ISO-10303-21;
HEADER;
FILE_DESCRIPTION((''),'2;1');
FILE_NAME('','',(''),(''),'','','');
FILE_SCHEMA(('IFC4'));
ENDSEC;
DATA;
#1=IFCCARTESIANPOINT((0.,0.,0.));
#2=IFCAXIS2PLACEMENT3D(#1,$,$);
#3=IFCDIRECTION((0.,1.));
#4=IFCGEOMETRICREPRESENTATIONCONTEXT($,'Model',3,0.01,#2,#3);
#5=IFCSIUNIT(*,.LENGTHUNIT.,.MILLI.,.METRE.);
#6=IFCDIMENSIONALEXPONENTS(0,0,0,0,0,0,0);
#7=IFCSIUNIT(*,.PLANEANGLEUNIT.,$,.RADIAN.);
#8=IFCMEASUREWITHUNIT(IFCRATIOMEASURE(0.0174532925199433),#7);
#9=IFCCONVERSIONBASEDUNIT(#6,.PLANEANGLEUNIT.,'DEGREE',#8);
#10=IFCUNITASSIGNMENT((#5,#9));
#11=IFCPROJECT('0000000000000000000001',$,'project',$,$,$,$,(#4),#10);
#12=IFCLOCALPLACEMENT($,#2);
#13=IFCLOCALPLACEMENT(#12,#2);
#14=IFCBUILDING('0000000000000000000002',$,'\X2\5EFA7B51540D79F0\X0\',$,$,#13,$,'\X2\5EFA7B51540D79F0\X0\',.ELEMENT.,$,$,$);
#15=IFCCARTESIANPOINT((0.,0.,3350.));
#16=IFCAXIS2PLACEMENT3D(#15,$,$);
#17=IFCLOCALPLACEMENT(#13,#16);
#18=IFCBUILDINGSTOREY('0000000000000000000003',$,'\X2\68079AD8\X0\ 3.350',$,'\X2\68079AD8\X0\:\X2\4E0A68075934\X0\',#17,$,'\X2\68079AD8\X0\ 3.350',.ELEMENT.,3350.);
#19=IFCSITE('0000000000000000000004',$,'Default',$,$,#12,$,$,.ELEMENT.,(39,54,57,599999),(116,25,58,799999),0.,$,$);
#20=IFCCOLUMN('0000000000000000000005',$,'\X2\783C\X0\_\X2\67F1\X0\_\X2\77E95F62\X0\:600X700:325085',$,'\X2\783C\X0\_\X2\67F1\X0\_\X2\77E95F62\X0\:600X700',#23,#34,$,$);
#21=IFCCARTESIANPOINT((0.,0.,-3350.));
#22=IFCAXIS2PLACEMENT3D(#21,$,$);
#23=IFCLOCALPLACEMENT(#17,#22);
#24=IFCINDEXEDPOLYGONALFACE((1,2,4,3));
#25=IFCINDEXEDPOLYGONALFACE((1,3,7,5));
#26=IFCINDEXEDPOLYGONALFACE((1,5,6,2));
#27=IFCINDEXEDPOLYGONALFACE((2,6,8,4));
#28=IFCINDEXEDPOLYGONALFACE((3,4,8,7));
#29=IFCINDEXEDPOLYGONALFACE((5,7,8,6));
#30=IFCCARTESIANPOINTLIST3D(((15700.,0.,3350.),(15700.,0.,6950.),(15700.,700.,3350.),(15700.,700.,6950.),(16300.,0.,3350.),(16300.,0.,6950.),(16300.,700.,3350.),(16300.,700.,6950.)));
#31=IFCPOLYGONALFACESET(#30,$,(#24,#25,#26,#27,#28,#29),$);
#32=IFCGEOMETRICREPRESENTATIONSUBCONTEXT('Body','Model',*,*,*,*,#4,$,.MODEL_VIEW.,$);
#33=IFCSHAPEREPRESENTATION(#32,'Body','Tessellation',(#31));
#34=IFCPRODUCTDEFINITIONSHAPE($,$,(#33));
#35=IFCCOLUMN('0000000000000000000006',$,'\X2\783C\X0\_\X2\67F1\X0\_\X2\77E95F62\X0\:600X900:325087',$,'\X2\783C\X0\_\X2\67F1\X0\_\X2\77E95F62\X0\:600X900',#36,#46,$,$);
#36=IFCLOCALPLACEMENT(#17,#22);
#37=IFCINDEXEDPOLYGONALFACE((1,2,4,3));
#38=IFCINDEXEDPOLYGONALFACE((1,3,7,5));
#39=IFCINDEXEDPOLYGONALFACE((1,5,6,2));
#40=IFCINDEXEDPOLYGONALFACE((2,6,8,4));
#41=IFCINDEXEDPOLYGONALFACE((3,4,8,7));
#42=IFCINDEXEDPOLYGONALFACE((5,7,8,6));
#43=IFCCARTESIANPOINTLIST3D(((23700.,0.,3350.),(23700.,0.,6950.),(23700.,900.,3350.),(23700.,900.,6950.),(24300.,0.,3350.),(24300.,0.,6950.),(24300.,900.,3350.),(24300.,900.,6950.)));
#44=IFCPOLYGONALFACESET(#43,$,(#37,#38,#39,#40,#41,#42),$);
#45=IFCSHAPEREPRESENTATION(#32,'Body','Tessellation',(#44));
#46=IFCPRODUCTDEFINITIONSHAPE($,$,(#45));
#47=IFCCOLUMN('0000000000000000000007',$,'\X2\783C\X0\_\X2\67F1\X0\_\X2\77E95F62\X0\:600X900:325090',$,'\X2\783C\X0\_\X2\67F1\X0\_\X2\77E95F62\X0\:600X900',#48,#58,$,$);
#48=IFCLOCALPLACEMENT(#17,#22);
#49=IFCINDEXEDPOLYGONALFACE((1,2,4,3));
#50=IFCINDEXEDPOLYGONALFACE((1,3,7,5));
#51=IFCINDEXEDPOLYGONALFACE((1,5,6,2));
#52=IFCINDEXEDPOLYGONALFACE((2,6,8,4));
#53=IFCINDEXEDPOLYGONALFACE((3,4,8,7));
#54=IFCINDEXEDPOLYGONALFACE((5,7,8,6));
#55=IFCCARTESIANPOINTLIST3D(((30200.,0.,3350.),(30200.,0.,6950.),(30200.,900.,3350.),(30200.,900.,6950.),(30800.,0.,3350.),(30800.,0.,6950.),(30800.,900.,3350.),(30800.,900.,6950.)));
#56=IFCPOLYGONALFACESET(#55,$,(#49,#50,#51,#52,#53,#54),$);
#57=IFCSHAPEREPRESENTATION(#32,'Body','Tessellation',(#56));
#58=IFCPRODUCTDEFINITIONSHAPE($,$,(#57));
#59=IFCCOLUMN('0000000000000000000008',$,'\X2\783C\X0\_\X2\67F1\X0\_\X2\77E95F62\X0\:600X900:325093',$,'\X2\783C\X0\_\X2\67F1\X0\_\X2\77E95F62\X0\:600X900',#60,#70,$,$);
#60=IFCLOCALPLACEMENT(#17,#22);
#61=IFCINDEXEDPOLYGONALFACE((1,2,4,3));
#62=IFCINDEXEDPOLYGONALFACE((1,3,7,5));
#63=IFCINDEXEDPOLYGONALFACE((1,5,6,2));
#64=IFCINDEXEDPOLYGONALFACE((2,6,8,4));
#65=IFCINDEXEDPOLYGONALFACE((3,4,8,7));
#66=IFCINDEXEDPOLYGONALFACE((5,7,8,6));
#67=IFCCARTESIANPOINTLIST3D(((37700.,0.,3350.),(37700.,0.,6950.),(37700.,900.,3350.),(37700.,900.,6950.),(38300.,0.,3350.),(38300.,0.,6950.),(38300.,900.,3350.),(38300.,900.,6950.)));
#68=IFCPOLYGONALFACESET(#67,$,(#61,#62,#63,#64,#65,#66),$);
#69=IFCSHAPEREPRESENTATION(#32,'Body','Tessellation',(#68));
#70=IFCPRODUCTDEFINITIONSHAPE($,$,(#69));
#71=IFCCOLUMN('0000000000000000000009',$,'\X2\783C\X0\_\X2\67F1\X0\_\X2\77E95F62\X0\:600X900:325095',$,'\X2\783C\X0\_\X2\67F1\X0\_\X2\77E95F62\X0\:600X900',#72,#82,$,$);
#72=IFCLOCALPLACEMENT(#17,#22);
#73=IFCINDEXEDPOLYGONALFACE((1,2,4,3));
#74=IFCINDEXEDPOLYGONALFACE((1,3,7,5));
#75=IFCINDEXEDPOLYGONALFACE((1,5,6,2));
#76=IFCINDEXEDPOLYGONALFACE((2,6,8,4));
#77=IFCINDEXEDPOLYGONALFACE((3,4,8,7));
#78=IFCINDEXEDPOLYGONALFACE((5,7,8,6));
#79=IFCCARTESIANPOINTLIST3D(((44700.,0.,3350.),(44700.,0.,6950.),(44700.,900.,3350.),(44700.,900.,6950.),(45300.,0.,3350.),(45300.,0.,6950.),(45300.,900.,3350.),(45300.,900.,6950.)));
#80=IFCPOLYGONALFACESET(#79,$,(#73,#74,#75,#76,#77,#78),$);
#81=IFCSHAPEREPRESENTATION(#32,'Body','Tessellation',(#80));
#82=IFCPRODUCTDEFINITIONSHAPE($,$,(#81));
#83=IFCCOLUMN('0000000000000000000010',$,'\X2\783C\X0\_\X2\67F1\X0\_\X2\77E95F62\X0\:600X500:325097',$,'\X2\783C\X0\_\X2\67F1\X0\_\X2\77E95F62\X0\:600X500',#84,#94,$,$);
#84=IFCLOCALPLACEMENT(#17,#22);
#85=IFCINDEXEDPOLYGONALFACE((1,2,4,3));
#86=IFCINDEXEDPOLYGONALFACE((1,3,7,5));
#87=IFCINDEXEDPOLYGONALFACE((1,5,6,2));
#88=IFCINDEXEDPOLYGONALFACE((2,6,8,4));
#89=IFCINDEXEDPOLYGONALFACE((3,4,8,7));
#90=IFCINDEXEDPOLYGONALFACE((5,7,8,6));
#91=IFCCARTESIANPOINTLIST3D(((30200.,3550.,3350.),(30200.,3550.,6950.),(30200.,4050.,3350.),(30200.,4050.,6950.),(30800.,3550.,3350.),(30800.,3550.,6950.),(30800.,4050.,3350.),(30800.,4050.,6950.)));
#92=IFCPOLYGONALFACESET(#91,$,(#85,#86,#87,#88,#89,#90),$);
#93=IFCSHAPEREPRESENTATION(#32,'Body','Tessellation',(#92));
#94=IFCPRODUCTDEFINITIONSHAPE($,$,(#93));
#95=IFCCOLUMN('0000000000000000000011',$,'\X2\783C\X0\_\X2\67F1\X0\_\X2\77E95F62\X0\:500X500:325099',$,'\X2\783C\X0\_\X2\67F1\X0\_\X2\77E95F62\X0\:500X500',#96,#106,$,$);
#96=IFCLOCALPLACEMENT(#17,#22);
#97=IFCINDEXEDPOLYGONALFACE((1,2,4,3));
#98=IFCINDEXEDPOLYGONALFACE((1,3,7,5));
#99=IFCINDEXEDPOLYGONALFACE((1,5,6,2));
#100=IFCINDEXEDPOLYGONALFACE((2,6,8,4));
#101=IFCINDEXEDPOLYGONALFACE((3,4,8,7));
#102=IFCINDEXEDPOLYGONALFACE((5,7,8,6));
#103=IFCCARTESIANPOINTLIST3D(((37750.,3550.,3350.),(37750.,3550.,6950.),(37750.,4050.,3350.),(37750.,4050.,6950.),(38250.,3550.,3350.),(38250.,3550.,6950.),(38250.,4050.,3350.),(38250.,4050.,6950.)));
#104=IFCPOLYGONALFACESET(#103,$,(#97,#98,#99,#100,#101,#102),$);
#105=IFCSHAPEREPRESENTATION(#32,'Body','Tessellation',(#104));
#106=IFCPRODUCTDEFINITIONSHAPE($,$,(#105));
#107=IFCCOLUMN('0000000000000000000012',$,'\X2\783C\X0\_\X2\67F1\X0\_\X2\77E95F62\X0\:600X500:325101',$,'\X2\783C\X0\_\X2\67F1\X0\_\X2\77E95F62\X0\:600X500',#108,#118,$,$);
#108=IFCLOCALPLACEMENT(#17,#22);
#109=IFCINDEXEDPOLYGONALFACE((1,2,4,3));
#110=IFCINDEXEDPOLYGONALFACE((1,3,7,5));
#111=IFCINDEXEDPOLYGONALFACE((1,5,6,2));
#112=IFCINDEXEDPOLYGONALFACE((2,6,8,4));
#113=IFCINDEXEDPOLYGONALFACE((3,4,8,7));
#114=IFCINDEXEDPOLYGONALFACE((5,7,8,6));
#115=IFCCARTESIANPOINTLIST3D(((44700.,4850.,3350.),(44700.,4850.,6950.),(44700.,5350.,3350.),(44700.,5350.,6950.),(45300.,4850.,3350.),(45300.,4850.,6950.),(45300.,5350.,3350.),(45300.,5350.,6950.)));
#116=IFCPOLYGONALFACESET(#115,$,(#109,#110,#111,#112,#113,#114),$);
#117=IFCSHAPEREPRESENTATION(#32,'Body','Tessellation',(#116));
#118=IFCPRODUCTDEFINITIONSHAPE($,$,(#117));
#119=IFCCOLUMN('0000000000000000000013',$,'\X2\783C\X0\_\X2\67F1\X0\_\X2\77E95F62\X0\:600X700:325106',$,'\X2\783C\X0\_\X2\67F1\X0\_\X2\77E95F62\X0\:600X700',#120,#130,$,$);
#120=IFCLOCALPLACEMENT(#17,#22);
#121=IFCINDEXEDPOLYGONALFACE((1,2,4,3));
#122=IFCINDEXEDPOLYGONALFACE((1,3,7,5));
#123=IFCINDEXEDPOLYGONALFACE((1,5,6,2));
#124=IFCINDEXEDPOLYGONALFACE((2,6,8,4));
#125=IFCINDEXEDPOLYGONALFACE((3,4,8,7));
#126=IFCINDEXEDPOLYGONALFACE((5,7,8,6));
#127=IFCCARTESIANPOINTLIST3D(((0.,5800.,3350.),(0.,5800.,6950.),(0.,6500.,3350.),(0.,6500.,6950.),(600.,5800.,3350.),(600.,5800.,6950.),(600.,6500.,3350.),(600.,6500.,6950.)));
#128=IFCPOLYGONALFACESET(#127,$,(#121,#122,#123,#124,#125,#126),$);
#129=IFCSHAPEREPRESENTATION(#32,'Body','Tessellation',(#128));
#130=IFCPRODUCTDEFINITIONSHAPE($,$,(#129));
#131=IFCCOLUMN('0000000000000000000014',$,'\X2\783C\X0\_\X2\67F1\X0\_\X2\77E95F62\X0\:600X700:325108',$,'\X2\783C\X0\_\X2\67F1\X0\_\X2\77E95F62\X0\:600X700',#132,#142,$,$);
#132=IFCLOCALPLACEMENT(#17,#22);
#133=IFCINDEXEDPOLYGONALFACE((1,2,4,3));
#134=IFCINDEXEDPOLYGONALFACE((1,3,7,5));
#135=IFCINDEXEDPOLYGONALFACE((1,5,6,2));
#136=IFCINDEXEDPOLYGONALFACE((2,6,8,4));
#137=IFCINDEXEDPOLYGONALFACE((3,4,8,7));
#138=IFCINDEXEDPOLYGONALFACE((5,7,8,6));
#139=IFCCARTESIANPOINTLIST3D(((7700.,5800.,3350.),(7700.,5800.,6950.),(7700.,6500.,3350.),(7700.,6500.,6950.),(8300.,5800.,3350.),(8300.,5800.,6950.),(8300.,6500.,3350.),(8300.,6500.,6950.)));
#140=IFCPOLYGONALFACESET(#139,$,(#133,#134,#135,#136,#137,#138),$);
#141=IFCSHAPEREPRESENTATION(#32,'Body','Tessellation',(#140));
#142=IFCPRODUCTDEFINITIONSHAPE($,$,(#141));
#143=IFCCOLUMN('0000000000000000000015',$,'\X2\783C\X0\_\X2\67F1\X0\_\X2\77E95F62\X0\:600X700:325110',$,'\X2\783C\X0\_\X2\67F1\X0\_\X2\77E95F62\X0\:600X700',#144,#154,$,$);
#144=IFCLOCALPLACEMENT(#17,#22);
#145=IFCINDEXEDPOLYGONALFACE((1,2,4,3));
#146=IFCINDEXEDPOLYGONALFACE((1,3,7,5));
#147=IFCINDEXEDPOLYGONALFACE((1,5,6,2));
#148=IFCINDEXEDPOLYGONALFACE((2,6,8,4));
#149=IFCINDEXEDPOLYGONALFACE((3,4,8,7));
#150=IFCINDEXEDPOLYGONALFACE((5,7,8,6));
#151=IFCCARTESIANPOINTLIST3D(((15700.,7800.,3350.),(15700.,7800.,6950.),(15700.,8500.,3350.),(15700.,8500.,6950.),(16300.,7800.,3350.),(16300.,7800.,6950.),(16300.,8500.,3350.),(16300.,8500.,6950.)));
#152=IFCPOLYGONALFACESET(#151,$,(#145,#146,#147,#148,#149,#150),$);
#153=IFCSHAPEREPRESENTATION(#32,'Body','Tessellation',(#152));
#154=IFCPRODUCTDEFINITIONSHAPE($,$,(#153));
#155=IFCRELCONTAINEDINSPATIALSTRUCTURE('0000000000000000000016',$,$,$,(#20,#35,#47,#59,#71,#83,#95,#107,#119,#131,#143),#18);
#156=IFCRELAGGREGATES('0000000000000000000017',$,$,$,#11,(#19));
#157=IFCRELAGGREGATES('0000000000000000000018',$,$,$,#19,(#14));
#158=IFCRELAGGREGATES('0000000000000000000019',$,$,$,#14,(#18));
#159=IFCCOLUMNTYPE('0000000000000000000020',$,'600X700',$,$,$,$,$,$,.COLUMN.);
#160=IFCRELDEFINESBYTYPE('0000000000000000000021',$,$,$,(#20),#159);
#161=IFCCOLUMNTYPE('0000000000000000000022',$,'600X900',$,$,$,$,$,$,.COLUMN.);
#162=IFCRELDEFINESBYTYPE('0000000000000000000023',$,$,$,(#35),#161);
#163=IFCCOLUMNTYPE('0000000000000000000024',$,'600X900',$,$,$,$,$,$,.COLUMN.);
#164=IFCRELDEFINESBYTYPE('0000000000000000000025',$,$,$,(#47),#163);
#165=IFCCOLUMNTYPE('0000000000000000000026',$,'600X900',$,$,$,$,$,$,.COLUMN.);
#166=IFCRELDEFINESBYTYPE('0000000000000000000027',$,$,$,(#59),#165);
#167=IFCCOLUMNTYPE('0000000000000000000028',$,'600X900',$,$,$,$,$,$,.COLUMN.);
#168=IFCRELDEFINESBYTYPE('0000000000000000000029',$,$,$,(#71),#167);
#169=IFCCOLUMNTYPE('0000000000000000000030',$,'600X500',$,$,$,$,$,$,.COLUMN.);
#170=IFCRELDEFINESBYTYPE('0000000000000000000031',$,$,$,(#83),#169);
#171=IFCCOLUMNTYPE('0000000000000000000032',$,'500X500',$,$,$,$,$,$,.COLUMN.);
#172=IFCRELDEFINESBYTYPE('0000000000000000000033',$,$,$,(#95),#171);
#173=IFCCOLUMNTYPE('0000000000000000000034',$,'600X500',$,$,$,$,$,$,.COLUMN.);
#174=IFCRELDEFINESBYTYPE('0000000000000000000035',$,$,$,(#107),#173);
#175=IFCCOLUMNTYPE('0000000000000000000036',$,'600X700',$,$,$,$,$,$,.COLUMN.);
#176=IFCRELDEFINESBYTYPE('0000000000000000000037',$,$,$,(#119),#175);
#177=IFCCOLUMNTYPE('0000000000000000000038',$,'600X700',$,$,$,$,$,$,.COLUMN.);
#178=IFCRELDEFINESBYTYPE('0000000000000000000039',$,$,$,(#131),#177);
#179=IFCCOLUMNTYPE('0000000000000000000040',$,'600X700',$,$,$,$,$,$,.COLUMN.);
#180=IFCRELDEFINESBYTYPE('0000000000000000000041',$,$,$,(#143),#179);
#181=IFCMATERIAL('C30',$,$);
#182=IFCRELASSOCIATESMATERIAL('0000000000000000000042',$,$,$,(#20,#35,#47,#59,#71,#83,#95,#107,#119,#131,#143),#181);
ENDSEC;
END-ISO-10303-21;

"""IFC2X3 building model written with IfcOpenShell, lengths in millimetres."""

from ifc_helpers import new_model, entity, si_unit, converted_unit, direction, frame, frame_2d, origin, origin_2d_with_axis, place, context, subcontext, project, spatial, rectangle, extrude, source, transform, mapped, material, type_object, type_shapes, element, save


model = new_model("IFC2X3")

# Units and contexts
model_context = context("Model", 3, precision=0.01, world=origin(), true_north=direction((0.0, 1.0)))
body_context = subcontext(model_context, "Body", "Model", "MODEL_VIEW")
ifc_project = project(units=[si_unit("LENGTHUNIT", "METRE", prefix="MILLI"), converted_unit("PLANEANGLEUNIT", "DEGREE", entity("IfcRatioMeasure", 0.0174532925199433), si_unit("PLANEANGLEUNIT", "RADIAN"), dimensions=[0, 0, 0, 0, 0, 0, 0])], contexts=[model_context])

# Site, building, storey
site_placement = place(None, origin())
site = spatial("IfcSite", under=ifc_project, at=site_placement, Name="Default", CompositionType="ELEMENT", RefLatitude=(39, 54, 57, 599999), RefLongitude=(116, 25, 58, 799999), RefElevation=0.0)
building_placement = place(site_placement, origin())
building = spatial("IfcBuilding", under=site, at=building_placement, Name="建筑名称", LongName="建筑名称", CompositionType="ELEMENT")
storey_placement = place(building_placement, frame((0.0, 0.0, 3350.0)))
storey = spatial("IfcBuildingStorey", under=building, at=storey_placement, Name="标高 3.350", ObjectType="标高:上标头", LongName="标高 3.350", CompositionType="ELEMENT", Elevation=3350.0)

# Columns
ifc_material = material(Name="C30")
column_type_1 = type_object("IfcColumnType", Name="600X700", PredefinedType="COLUMN")
shared_shape_1 = source(origin(), body_context, "Body", "SweptSolid", [
    extrude(rectangle(XDim=700.0, YDim=600.0, at=frame_2d((0.0, 0.0), x_axis=(1.0, 0.0))), frame((16000.0, 350.0, 3350.0), z_axis=(0.0, 0.0, 1.0), x_axis=(0.0, -1.0, 0.0)), (0.0, 0.0, 1.0), 3600.0),
])
type_shapes(column_type_1, [shared_shape_1])
column_1_placement = place(storey_placement, frame((0.0, 0.0, -3350.0)))
element("IfcColumn", 1, at=column_1_placement, inside=storey, type_object=column_type_1, material=ifc_material, Name="砼_柱_矩形:600X700:325085", ObjectType="砼_柱_矩形:600X700", context=body_context, shape_type="MappedRepresentation", body=[
    mapped(shared_shape_1, transform((0.0, 0.0, 0.0), scale=1.0)),
])
column_type_2 = type_object("IfcColumnType", Name="600X900", PredefinedType="COLUMN")
shared_shape_2 = source(origin(), body_context, "Body", "SweptSolid", [
    extrude(rectangle(XDim=900.0, YDim=600.0, at=origin_2d_with_axis()), frame((24000.0, 450.0, 3350.0), z_axis=(0.0, 0.0, 1.0), x_axis=(0.0, -1.0, 0.0)), (0.0, 0.0, 1.0), 3600.0),
])
type_shapes(column_type_2, [shared_shape_2])
column_2_placement = place(storey_placement, frame((0.0, 0.0, -3350.0)))
element("IfcColumn", 2, at=column_2_placement, inside=storey, type_object=column_type_2, material=ifc_material, Name="砼_柱_矩形:600X900:325087", ObjectType="砼_柱_矩形:600X900", context=body_context, shape_type="MappedRepresentation", body=[
    mapped(shared_shape_2, transform((0.0, 0.0, 0.0), scale=1.0)),
])
column_type_3 = type_object("IfcColumnType", Name="600X900", PredefinedType="COLUMN")
shared_shape_3 = source(origin(), body_context, "Body", "SweptSolid", [
    extrude(rectangle(XDim=900.0, YDim=600.0, at=origin_2d_with_axis()), frame((30500.0, 450.0, 3350.0), z_axis=(0.0, 0.0, 1.0), x_axis=(0.0, -1.0, 0.0)), (0.0, 0.0, 1.0), 3600.0),
])
type_shapes(column_type_3, [shared_shape_3])
column_3_placement = place(storey_placement, frame((0.0, 0.0, -3350.0)))
element("IfcColumn", 3, at=column_3_placement, inside=storey, type_object=column_type_3, material=ifc_material, Name="砼_柱_矩形:600X900:325090", ObjectType="砼_柱_矩形:600X900", context=body_context, shape_type="MappedRepresentation", body=[
    mapped(shared_shape_3, transform((0.0, 0.0, 0.0), scale=1.0)),
])
column_type_4 = type_object("IfcColumnType", Name="600X900", PredefinedType="COLUMN")
shared_shape_4 = source(origin(), body_context, "Body", "SweptSolid", [
    extrude(rectangle(XDim=900.0, YDim=600.0, at=origin_2d_with_axis()), frame((38000.0, 450.0, 3350.0), z_axis=(0.0, 0.0, 1.0), x_axis=(0.0, -1.0, 0.0)), (0.0, 0.0, 1.0), 3600.0),
])
type_shapes(column_type_4, [shared_shape_4])
column_4_placement = place(storey_placement, frame((0.0, 0.0, -3350.0)))
element("IfcColumn", 4, at=column_4_placement, inside=storey, type_object=column_type_4, material=ifc_material, Name="砼_柱_矩形:600X900:325093", ObjectType="砼_柱_矩形:600X900", context=body_context, shape_type="MappedRepresentation", body=[
    mapped(shared_shape_4, transform((0.0, 0.0, 0.0), scale=1.0)),
])
column_type_5 = type_object("IfcColumnType", Name="600X900", PredefinedType="COLUMN")
shared_shape_5 = source(origin(), body_context, "Body", "SweptSolid", [
    extrude(rectangle(XDim=900.0, YDim=600.0, at=origin_2d_with_axis()), frame((45000.0, 450.0, 3350.0), z_axis=(0.0, 0.0, 1.0), x_axis=(0.0, -1.0, 0.0)), (0.0, 0.0, 1.0), 3600.0),
])
type_shapes(column_type_5, [shared_shape_5])
column_5_placement = place(storey_placement, frame((0.0, 0.0, -3350.0)))
element("IfcColumn", 5, at=column_5_placement, inside=storey, type_object=column_type_5, material=ifc_material, Name="砼_柱_矩形:600X900:325095", ObjectType="砼_柱_矩形:600X900", context=body_context, shape_type="MappedRepresentation", body=[
    mapped(shared_shape_5, transform((0.0, 0.0, 0.0), scale=1.0)),
])
column_type_6 = type_object("IfcColumnType", Name="600X500", PredefinedType="COLUMN")
shared_shape_6 = source(origin(), body_context, "Body", "SweptSolid", [
    extrude(rectangle(XDim=500.0, YDim=600.0, at=origin_2d_with_axis()), frame((30500.0, 3800.0, 3350.0), z_axis=(0.0, 0.0, 1.0), x_axis=(0.0, -1.0, 0.0)), (0.0, 0.0, 1.0), 3600.0),
])
type_shapes(column_type_6, [shared_shape_6])
column_6_placement = place(storey_placement, frame((0.0, 0.0, -3350.0)))
element("IfcColumn", 6, at=column_6_placement, inside=storey, type_object=column_type_6, material=ifc_material, Name="砼_柱_矩形:600X500:325097", ObjectType="砼_柱_矩形:600X500", context=body_context, shape_type="MappedRepresentation", body=[
    mapped(shared_shape_6, transform((0.0, 0.0, 0.0), scale=1.0)),
])
column_type_7 = type_object("IfcColumnType", Name="500X500", PredefinedType="COLUMN")
shared_shape_7 = source(origin(), body_context, "Body", "SweptSolid", [
    extrude(rectangle(XDim=500.0, YDim=500.0, at=origin_2d_with_axis()), frame((38000.0, 3800.0, 3350.0), z_axis=(0.0, 0.0, 1.0), x_axis=(0.0, -1.0, 0.0)), (0.0, 0.0, 1.0), 3600.0),
])
type_shapes(column_type_7, [shared_shape_7])
column_7_placement = place(storey_placement, frame((0.0, 0.0, -3350.0)))
element("IfcColumn", 7, at=column_7_placement, inside=storey, type_object=column_type_7, material=ifc_material, Name="砼_柱_矩形:500X500:325099", ObjectType="砼_柱_矩形:500X500", context=body_context, shape_type="MappedRepresentation", body=[
    mapped(shared_shape_7, transform((0.0, 0.0, 0.0), scale=1.0)),
])
column_type_8 = type_object("IfcColumnType", Name="600X500", PredefinedType="COLUMN")
shared_shape_8 = source(origin(), body_context, "Body", "SweptSolid", [
    extrude(rectangle(XDim=500.0, YDim=600.0, at=frame_2d((0.0, 0.0), x_axis=(1.0, 0.0))), frame((45000.0, 5100.0, 3350.0), z_axis=(0.0, 0.0, 1.0), x_axis=(0.0, -1.0, 0.0)), (0.0, 0.0, 1.0), 3600.0),
])
type_shapes(column_type_8, [shared_shape_8])
column_8_placement = place(storey_placement, frame((0.0, 0.0, -3350.0)))
element("IfcColumn", 8, at=column_8_placement, inside=storey, type_object=column_type_8, material=ifc_material, Name="砼_柱_矩形:600X500:325101", ObjectType="砼_柱_矩形:600X500", context=body_context, shape_type="MappedRepresentation", body=[
    mapped(shared_shape_8, transform((0.0, 0.0, 0.0), scale=1.0)),
])
column_type_9 = type_object("IfcColumnType", Name="600X700", PredefinedType="COLUMN")
shared_shape_9 = source(origin(), body_context, "Body", "SweptSolid", [
    extrude(rectangle(XDim=700.0, YDim=600.0, at=origin_2d_with_axis()), frame((300.0, 6150.0, 3350.0), z_axis=(0.0, 0.0, 1.0), x_axis=(0.0, -1.0, 0.0)), (0.0, 0.0, 1.0), 3600.0),
])
type_shapes(column_type_9, [shared_shape_9])
column_9_placement = place(storey_placement, frame((0.0, 0.0, -3350.0)))
element("IfcColumn", 9, at=column_9_placement, inside=storey, type_object=column_type_9, material=ifc_material, Name="砼_柱_矩形:600X700:325106", ObjectType="砼_柱_矩形:600X700", context=body_context, shape_type="MappedRepresentation", body=[
    mapped(shared_shape_9, transform((0.0, 0.0, 0.0), scale=1.0)),
])
column_type_10 = type_object("IfcColumnType", Name="600X700", PredefinedType="COLUMN")
shared_shape_10 = source(origin(), body_context, "Body", "SweptSolid", [
    extrude(rectangle(XDim=700.0, YDim=600.0, at=origin_2d_with_axis()), frame((8000.0, 6150.0, 3350.0), z_axis=(0.0, 0.0, 1.0), x_axis=(0.0, -1.0, 0.0)), (0.0, 0.0, 1.0), 3600.0),
])
type_shapes(column_type_10, [shared_shape_10])
column_10_placement = place(storey_placement, frame((0.0, 0.0, -3350.0)))
element("IfcColumn", 10, at=column_10_placement, inside=storey, type_object=column_type_10, material=ifc_material, Name="砼_柱_矩形:600X700:325108", ObjectType="砼_柱_矩形:600X700", context=body_context, shape_type="MappedRepresentation", body=[
    mapped(shared_shape_10, transform((0.0, 0.0, 0.0), scale=1.0)),
])
column_type_11 = type_object("IfcColumnType", Name="600X700", PredefinedType="COLUMN")
shared_shape_11 = source(origin(), body_context, "Body", "SweptSolid", [
    extrude(rectangle(XDim=700.0, YDim=600.0, at=frame_2d((0.0, 0.0), x_axis=(1.0, 0.0))), frame((16000.0, 8150.0, 3350.0), z_axis=(0.0, 0.0, 1.0), x_axis=(0.0, -1.0, 0.0)), (0.0, 0.0, 1.0), 3600.0),
])
type_shapes(column_type_11, [shared_shape_11])
column_11_placement = place(storey_placement, frame((0.0, 0.0, -3350.0)))
element("IfcColumn", 11, at=column_11_placement, inside=storey, type_object=column_type_11, material=ifc_material, Name="砼_柱_矩形:600X700:325110", ObjectType="砼_柱_矩形:600X700", context=body_context, shape_type="MappedRepresentation", body=[
    mapped(shared_shape_11, transform((0.0, 0.0, 0.0), scale=1.0)),
])

save(model, "model.ifc")
